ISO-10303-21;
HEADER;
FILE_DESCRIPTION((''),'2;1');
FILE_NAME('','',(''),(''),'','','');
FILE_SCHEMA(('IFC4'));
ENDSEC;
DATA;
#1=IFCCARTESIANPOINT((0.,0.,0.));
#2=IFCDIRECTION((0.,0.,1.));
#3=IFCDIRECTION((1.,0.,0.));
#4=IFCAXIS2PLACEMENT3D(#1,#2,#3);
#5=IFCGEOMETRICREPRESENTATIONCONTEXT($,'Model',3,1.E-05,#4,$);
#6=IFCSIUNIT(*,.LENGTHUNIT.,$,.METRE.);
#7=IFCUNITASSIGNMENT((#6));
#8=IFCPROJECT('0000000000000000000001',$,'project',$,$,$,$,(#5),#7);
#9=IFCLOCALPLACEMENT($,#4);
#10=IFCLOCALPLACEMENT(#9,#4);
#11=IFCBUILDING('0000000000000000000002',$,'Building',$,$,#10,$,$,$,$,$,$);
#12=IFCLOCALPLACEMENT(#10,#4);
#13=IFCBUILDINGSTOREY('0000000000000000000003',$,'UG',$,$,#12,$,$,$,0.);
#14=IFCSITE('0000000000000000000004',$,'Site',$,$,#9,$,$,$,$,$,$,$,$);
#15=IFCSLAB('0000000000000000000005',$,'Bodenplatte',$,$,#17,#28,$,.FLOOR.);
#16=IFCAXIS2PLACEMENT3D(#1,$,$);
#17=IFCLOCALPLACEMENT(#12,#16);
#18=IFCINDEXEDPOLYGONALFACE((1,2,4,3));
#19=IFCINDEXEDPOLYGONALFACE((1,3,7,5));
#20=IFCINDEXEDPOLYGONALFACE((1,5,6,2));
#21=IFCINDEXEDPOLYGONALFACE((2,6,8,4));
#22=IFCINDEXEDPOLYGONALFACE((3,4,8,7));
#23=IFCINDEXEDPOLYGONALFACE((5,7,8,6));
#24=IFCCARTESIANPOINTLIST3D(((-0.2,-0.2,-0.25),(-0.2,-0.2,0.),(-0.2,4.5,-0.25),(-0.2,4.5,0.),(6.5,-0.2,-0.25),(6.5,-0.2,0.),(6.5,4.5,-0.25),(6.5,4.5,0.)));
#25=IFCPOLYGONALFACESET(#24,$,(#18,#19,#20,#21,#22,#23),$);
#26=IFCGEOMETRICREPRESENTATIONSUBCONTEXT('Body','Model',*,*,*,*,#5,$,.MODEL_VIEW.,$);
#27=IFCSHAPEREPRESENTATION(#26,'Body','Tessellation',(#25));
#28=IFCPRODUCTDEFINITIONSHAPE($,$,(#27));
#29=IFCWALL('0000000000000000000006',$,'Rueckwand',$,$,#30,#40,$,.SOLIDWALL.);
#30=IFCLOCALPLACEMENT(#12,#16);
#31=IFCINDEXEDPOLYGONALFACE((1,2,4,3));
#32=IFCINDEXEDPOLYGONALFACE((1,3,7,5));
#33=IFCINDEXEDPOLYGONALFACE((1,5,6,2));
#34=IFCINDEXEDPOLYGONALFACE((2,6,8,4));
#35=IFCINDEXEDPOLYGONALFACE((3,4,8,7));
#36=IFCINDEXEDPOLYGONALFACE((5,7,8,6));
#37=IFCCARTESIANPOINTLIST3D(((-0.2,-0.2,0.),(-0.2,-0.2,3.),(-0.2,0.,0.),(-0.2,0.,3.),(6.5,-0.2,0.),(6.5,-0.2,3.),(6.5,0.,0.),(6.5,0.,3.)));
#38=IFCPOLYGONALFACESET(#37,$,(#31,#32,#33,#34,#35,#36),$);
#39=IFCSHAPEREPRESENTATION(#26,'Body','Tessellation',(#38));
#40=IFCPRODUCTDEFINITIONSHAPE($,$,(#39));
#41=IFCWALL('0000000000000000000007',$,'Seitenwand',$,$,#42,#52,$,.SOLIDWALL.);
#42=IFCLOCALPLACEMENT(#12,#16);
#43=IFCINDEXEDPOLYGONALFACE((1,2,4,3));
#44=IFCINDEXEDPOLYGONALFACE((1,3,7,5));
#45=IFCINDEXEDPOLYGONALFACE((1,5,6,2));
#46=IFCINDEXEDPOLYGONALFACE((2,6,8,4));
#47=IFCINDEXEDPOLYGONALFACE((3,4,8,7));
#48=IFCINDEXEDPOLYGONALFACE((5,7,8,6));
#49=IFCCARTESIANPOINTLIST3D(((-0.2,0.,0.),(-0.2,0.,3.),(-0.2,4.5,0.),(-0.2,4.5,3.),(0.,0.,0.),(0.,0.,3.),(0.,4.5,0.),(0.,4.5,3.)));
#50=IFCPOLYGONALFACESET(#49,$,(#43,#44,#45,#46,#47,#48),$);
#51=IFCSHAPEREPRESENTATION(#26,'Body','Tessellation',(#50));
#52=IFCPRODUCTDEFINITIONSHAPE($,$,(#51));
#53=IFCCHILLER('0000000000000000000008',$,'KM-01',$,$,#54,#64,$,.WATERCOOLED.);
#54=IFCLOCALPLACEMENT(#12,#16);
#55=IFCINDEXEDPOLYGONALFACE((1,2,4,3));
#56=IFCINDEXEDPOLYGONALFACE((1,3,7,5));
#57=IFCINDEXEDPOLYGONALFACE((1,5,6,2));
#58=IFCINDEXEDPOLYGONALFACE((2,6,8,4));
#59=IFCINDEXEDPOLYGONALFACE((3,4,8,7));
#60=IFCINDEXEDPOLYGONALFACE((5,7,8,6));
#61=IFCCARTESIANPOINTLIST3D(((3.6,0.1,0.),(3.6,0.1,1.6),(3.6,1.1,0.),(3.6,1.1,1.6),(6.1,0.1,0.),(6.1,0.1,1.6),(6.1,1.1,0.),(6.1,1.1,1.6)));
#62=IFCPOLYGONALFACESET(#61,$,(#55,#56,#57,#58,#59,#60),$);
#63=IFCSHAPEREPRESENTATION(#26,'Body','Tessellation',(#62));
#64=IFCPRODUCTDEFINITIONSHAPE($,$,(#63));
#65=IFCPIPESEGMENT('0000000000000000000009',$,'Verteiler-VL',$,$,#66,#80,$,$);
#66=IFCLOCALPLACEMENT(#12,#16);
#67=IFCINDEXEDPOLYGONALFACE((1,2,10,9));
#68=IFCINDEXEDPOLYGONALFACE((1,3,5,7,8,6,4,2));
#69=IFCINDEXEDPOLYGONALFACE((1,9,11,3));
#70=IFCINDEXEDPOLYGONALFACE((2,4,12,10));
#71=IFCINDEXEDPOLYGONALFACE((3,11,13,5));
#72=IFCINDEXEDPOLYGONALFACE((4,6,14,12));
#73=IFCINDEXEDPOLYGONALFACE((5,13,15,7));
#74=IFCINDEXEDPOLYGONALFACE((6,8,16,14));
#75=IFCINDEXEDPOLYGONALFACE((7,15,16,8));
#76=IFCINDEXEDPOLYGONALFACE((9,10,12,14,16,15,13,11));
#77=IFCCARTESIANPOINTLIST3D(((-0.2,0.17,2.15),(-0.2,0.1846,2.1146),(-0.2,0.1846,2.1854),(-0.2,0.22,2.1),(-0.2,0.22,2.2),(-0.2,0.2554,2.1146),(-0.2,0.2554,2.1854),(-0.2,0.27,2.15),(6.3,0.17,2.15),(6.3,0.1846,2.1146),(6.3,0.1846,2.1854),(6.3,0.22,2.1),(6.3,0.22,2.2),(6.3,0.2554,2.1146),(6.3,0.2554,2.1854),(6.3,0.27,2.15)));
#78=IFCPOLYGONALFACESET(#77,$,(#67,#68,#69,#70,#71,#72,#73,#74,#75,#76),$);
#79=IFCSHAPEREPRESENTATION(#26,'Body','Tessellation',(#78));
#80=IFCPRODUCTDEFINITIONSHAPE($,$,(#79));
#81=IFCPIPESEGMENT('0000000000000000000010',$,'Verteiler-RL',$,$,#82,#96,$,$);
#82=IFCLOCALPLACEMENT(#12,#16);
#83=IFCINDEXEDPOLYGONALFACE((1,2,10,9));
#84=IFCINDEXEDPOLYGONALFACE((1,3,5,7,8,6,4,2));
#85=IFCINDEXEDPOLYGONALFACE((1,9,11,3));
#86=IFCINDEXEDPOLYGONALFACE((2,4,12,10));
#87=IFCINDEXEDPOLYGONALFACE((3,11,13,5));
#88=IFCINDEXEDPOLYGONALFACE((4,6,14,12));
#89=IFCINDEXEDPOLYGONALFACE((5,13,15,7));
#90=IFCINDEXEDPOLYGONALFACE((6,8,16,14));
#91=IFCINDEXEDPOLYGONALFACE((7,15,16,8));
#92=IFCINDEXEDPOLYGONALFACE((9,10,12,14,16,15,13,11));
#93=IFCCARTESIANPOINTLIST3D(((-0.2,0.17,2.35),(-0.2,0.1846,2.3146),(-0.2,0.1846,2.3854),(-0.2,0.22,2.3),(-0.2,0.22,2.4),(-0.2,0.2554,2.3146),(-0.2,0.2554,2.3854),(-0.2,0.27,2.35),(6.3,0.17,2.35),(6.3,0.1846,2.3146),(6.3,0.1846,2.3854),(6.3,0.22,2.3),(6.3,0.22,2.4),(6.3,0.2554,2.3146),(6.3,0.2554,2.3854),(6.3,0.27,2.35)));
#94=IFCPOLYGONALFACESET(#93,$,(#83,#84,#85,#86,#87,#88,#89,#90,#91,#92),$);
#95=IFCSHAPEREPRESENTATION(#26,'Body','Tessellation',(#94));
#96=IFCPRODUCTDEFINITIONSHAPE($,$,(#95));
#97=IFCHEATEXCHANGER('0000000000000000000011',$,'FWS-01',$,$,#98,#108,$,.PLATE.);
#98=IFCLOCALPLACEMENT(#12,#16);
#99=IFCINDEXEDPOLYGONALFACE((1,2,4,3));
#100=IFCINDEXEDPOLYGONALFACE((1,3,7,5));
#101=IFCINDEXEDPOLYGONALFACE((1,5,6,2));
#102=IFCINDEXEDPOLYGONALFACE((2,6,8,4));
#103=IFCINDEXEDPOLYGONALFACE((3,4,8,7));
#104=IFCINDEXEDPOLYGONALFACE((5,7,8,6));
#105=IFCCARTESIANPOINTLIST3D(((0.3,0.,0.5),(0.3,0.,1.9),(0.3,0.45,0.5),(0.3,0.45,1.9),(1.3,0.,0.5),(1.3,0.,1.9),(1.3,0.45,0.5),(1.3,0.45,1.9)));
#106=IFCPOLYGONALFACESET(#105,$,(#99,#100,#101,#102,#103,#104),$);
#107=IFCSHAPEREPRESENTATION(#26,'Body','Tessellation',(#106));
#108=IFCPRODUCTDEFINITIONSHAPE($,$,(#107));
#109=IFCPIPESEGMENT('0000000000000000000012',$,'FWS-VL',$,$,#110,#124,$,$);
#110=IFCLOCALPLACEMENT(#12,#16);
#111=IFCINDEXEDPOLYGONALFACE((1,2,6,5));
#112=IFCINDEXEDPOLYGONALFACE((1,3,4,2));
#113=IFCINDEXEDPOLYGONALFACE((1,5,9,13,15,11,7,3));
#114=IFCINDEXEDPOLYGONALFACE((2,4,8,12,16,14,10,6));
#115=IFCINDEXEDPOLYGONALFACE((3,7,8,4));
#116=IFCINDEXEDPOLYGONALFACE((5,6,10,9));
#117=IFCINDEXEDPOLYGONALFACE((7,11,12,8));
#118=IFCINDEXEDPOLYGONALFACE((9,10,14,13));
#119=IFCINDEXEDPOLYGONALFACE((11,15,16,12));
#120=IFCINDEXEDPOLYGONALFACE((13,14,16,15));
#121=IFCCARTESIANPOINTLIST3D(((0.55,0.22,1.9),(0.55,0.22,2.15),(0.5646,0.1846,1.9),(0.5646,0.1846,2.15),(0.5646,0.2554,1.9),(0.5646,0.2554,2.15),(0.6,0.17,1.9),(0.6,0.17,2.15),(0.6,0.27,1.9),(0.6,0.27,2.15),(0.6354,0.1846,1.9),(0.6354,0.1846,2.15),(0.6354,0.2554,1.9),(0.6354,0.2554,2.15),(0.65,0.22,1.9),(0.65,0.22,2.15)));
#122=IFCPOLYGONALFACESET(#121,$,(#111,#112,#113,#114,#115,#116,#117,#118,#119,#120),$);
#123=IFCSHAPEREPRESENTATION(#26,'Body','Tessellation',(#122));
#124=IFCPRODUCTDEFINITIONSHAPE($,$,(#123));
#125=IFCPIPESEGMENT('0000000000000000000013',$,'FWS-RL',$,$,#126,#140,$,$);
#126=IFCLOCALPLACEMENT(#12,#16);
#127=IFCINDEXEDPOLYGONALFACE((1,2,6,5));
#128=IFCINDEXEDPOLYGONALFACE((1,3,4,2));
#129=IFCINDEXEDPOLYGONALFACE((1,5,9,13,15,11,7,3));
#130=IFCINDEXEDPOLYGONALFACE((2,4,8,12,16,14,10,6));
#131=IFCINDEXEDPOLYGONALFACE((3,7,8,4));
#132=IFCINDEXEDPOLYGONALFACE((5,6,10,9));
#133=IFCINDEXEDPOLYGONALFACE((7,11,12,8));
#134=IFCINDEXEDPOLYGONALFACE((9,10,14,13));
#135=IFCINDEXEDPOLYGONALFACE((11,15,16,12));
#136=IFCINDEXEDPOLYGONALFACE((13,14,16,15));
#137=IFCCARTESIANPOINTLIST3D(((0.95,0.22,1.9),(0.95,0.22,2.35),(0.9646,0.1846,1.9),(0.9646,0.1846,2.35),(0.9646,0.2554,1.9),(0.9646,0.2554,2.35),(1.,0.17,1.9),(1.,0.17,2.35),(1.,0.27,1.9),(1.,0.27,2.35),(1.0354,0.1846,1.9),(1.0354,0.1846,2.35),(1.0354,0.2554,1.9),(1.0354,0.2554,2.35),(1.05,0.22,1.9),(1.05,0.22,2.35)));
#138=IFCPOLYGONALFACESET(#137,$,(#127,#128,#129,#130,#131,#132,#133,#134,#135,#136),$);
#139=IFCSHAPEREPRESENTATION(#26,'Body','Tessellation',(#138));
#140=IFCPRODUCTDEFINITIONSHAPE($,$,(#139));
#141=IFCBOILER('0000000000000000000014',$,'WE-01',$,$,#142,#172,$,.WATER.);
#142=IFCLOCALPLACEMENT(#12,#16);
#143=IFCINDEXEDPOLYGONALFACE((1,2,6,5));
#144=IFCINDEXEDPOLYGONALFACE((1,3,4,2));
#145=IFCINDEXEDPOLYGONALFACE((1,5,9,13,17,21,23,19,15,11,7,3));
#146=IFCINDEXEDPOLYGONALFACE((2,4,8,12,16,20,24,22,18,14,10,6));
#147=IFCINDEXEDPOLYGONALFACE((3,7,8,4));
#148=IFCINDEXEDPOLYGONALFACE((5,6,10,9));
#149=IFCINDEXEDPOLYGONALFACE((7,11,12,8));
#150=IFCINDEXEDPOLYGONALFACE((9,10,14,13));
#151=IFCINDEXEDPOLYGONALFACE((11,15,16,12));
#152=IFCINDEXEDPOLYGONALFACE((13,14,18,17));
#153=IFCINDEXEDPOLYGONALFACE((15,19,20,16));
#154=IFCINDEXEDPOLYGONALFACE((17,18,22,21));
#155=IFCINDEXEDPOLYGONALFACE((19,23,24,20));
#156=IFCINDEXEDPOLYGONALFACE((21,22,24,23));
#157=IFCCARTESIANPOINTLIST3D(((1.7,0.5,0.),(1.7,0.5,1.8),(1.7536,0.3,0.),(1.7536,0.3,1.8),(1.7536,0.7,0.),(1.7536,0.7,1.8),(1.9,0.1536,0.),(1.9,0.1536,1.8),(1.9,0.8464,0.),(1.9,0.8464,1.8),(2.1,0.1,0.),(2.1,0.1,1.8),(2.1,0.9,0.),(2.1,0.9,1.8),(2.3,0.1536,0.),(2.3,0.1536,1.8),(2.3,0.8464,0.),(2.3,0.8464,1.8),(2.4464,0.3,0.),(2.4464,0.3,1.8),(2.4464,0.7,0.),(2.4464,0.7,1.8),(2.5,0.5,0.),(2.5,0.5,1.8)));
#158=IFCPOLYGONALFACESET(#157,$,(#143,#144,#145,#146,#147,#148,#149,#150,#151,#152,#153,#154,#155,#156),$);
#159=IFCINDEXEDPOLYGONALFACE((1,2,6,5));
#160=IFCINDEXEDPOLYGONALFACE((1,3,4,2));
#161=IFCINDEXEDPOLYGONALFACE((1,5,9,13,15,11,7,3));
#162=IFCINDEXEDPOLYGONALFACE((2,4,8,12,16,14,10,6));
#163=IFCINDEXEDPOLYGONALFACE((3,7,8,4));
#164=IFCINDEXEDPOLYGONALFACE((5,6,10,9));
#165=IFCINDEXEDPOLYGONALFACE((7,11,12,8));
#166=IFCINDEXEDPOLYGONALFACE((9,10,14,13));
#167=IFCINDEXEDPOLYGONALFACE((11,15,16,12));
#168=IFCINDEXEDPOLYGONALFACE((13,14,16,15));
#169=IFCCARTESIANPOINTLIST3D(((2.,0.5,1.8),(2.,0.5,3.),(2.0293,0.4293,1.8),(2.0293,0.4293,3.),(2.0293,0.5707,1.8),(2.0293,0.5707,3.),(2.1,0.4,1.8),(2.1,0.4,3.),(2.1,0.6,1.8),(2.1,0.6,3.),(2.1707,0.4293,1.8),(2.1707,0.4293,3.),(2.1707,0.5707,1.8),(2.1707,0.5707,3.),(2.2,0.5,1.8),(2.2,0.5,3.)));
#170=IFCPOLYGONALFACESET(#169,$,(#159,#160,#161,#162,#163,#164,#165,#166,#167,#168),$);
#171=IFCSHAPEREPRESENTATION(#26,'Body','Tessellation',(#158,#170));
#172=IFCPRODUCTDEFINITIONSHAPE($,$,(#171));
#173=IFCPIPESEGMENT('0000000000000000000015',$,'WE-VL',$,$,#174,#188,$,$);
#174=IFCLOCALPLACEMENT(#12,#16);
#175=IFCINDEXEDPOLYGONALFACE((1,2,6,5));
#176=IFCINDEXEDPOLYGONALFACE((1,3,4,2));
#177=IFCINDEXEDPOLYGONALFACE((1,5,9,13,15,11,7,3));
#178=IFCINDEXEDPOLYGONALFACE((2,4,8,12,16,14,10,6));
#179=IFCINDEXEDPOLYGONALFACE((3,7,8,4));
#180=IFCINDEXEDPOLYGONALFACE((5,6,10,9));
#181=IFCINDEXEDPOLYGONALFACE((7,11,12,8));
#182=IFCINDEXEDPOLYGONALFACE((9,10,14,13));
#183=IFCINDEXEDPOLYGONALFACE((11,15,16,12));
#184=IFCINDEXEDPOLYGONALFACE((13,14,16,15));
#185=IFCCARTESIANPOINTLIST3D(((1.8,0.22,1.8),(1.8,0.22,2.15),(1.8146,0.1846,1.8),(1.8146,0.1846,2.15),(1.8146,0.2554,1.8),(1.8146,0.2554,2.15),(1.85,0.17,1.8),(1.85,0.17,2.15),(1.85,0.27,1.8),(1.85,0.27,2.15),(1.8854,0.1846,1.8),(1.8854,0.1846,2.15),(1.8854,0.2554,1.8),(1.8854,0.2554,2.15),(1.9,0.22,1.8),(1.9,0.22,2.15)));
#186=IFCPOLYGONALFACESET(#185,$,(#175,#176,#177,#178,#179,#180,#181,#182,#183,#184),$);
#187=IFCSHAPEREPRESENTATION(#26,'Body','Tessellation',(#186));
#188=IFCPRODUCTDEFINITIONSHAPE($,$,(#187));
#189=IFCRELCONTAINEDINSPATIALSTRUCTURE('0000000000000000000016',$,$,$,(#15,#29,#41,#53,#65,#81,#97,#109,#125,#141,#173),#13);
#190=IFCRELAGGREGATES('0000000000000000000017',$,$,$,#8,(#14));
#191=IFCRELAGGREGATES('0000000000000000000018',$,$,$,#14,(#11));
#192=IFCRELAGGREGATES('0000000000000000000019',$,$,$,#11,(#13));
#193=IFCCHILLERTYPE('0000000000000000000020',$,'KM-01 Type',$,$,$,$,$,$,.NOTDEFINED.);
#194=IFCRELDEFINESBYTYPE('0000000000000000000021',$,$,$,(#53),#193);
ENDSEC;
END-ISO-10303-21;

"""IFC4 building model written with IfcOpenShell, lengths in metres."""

from ifc_helpers import new_model, si_unit, frame, origin_with_axes, place, context, subcontext, project, spatial, polyline, outline, extrude, type_object, element, save


model = new_model("IFC4")

# Units and contexts
model_context = context("Model", 3, precision=1e-05, world=origin_with_axes())
body_context = subcontext(model_context, "Body", "Model", "MODEL_VIEW")
ifc_project = project(units=[si_unit("LENGTHUNIT", "METRE")], contexts=[model_context])

# Site, building, storey
site_placement = place(None, origin_with_axes())
site = spatial("IfcSite", under=ifc_project, at=site_placement, Name="Site")
building_placement = place(site_placement, origin_with_axes())
building = spatial("IfcBuilding", under=site, at=building_placement, Name="Building")
storey_placement = place(building_placement, origin_with_axes())
storey = spatial("IfcBuildingStorey", under=building, at=storey_placement, Name="UG", Elevation=0.0)

# Slab
slab_placement = place(storey_placement, frame((0.0, 0.0, -0.25), z_axis=(0.0, 0.0, 1.0), x_axis=(1.0, 0.0, 0.0)))
element("IfcSlab", 1, at=slab_placement, inside=storey, Name="Bodenplatte", PredefinedType="FLOOR", context=body_context, shape_type="SweptSolid", body=[
    extrude(outline(polyline([(-0.2, -0.2, 0.0), (6.5, -0.2, 0.0), (6.5, 4.5, 0.0), (-0.2, 4.5, 0.0), (-0.2, -0.2, 0.0)])), origin_with_axes(), (0.0, 0.0, 1.0), 0.25),
])

# Walls
wall_1_placement = place(storey_placement, frame((-0.2, -0.2, 0.0), z_axis=(0.0, 0.0, 1.0), x_axis=(1.0, 0.0, 0.0)))
element("IfcWall", 2, at=wall_1_placement, inside=storey, Name="Rueckwand", PredefinedType="SOLIDWALL", context=body_context, shape_type="SweptSolid", body=[
    extrude(outline(polyline([(0.0, 0.0, 0.0), (6.7, 0.0, 0.0), (6.7, 0.2, 0.0), (0.0, 0.2, 0.0), (0.0, 0.0, 0.0)])), origin_with_axes(), (0.0, 0.0, 1.0), 3.0),
])
wall_2_placement = place(storey_placement, frame((0.0, 0.0, 0.0), z_axis=(0.0, 0.0, 1.0), x_axis=(0.0, 1.0, 0.0)))
element("IfcWall", 3, at=wall_2_placement, inside=storey, Name="Seitenwand", PredefinedType="SOLIDWALL", context=body_context, shape_type="SweptSolid", body=[
    extrude(outline(polyline([(0.0, 0.0, 0.0), (4.5, 0.0, 0.0), (4.5, 0.2, 0.0), (0.0, 0.2, 0.0), (0.0, 0.0, 0.0)])), origin_with_axes(), (0.0, 0.0, 1.0), 3.0),
])

# Chiller
chiller_type = type_object("IfcChillerType", Name="KM-01 Type", PredefinedType="NOTDEFINED")
chiller_placement = place(storey_placement, origin_with_axes())
element("IfcChiller", 4, at=chiller_placement, inside=storey, type_object=chiller_type, Name="KM-01", PredefinedType="WATERCOOLED", context=body_context, shape_type="SweptSolid", body=[
    extrude(outline(polyline([(3.6, 0.1, 0.0), (6.1, 0.1, 0.0), (6.1, 1.1, 0.0), (3.6, 1.1, 0.0), (3.6, 0.1, 0.0)])), origin_with_axes(), (0.0, 0.0, 1.0), 1.6),
])

# Pipe segments
pipe_segment_1_placement = place(storey_placement, origin_with_axes())
element("IfcPipeSegment", 5, at=pipe_segment_1_placement, inside=storey, Name="Verteiler-VL", context=body_context, shape_type="SweptSolid", body=[
    extrude(outline(polyline([(0.05, 0.0, 0.0), (0.0354, 0.0354, 0.0), (0.0, 0.05, 0.0), (-0.0354, 0.0354, 0.0), (-0.05, 0.0, 0.0), (-0.0354, -0.0354, 0.0), (0.0, -0.05, 0.0), (0.0354, -0.0354, 0.0), (0.05, 0.0, 0.0)])), frame((-0.2, 0.22, 2.15), z_axis=(1.0, 0.0, 0.0), x_axis=(0.0, 1.0, 0.0)), (0.0, 0.0, 1.0), 6.5),
])
pipe_segment_2_placement = place(storey_placement, origin_with_axes())
element("IfcPipeSegment", 6, at=pipe_segment_2_placement, inside=storey, Name="Verteiler-RL", context=body_context, shape_type="SweptSolid", body=[
    extrude(outline(polyline([(0.05, 0.0, 0.0), (0.0354, 0.0354, 0.0), (0.0, 0.05, 0.0), (-0.0354, 0.0354, 0.0), (-0.05, 0.0, 0.0), (-0.0354, -0.0354, 0.0), (0.0, -0.05, 0.0), (0.0354, -0.0354, 0.0), (0.05, 0.0, 0.0)])), frame((-0.2, 0.22, 2.35), z_axis=(1.0, 0.0, 0.0), x_axis=(0.0, 1.0, 0.0)), (0.0, 0.0, 1.0), 6.5),
])

# Heat exchanger
heat_exchanger_placement = place(storey_placement, origin_with_axes())
element("IfcHeatExchanger", 7, at=heat_exchanger_placement, inside=storey, Name="FWS-01", PredefinedType="PLATE", context=body_context, shape_type="SweptSolid", body=[
    extrude(outline(polyline([(0.3, 0.0, 0.0), (1.3, 0.0, 0.0), (1.3, 0.45, 0.0), (0.3, 0.45, 0.0), (0.3, 0.0, 0.0)])), frame((0.0, 0.0, 0.5), z_axis=(0.0, 0.0, 1.0), x_axis=(1.0, 0.0, 0.0)), (0.0, 0.0, 1.0), 1.4),
])

# Pipe segments
pipe_segment_3_placement = place(storey_placement, origin_with_axes())
element("IfcPipeSegment", 8, at=pipe_segment_3_placement, inside=storey, Name="FWS-VL", context=body_context, shape_type="SweptSolid", body=[
    extrude(outline(polyline([(0.05, 0.0, 0.0), (0.0354, 0.0354, 0.0), (0.0, 0.05, 0.0), (-0.0354, 0.0354, 0.0), (-0.05, 0.0, 0.0), (-0.0354, -0.0354, 0.0), (0.0, -0.05, 0.0), (0.0354, -0.0354, 0.0), (0.05, 0.0, 0.0)])), frame((0.6, 0.22, 1.9), z_axis=(0.0, 0.0, 1.0), x_axis=(1.0, 0.0, 0.0)), (0.0, 0.0, 1.0), 0.25),
])
pipe_segment_4_placement = place(storey_placement, origin_with_axes())
element("IfcPipeSegment", 9, at=pipe_segment_4_placement, inside=storey, Name="FWS-RL", context=body_context, shape_type="SweptSolid", body=[
    extrude(outline(polyline([(0.05, 0.0, 0.0), (0.0354, 0.0354, 0.0), (0.0, 0.05, 0.0), (-0.0354, 0.0354, 0.0), (-0.05, 0.0, 0.0), (-0.0354, -0.0354, 0.0), (0.0, -0.05, 0.0), (0.0354, -0.0354, 0.0), (0.05, 0.0, 0.0)])), frame((1.0, 0.22, 1.9), z_axis=(0.0, 0.0, 1.0), x_axis=(1.0, 0.0, 0.0)), (0.0, 0.0, 1.0), 0.45),
])

# Boiler
boiler_placement = place(storey_placement, origin_with_axes())
element("IfcBoiler", 10, at=boiler_placement, inside=storey, Name="WE-01", PredefinedType="WATER", context=body_context, shape_type="SweptSolid", body=[
    extrude(outline(polyline([(0.4, 0.0, 0.0), (0.3464, 0.2, 0.0), (0.2, 0.3464, 0.0), (0.0, 0.4, 0.0), (-0.2, 0.3464, 0.0), (-0.3464, 0.2, 0.0), (-0.4, 0.0, 0.0), (-0.3464, -0.2, 0.0), (-0.2, -0.3464, 0.0), (0.0, -0.4, 0.0), (0.2, -0.3464, 0.0), (0.3464, -0.2, 0.0), (0.4, 0.0, 0.0)])), frame((2.1, 0.5, 0.0), z_axis=(0.0, 0.0, 1.0), x_axis=(1.0, 0.0, 0.0)), (0.0, 0.0, 1.0), 1.8),
    extrude(outline(polyline([(0.1, 0.0, 0.0), (0.0707, 0.0707, 0.0), (0.0, 0.1, 0.0), (-0.0707, 0.0707, 0.0), (-0.1, 0.0, 0.0), (-0.0707, -0.0707, 0.0), (0.0, -0.1, 0.0), (0.0707, -0.0707, 0.0), (0.1, 0.0, 0.0)])), frame((2.1, 0.5, 1.8), z_axis=(0.0, 0.0, 1.0), x_axis=(1.0, 0.0, 0.0)), (0.0, 0.0, 1.0), 1.2),
])

# Pipe segment
pipe_segment_5_placement = place(storey_placement, origin_with_axes())
element("IfcPipeSegment", 11, at=pipe_segment_5_placement, inside=storey, Name="WE-VL", context=body_context, shape_type="SweptSolid", body=[
    extrude(outline(polyline([(0.05, 0.0, 0.0), (0.0354, 0.0354, 0.0), (0.0, 0.05, 0.0), (-0.0354, 0.0354, 0.0), (-0.05, 0.0, 0.0), (-0.0354, -0.0354, 0.0), (0.0, -0.05, 0.0), (0.0354, -0.0354, 0.0), (0.05, 0.0, 0.0)])), frame((1.85, 0.22, 1.8), z_axis=(0.0, 0.0, 1.0), x_axis=(1.0, 0.0, 0.0)), (0.0, 0.0, 1.0), 0.35),
])

save(model, "model.ifc")
